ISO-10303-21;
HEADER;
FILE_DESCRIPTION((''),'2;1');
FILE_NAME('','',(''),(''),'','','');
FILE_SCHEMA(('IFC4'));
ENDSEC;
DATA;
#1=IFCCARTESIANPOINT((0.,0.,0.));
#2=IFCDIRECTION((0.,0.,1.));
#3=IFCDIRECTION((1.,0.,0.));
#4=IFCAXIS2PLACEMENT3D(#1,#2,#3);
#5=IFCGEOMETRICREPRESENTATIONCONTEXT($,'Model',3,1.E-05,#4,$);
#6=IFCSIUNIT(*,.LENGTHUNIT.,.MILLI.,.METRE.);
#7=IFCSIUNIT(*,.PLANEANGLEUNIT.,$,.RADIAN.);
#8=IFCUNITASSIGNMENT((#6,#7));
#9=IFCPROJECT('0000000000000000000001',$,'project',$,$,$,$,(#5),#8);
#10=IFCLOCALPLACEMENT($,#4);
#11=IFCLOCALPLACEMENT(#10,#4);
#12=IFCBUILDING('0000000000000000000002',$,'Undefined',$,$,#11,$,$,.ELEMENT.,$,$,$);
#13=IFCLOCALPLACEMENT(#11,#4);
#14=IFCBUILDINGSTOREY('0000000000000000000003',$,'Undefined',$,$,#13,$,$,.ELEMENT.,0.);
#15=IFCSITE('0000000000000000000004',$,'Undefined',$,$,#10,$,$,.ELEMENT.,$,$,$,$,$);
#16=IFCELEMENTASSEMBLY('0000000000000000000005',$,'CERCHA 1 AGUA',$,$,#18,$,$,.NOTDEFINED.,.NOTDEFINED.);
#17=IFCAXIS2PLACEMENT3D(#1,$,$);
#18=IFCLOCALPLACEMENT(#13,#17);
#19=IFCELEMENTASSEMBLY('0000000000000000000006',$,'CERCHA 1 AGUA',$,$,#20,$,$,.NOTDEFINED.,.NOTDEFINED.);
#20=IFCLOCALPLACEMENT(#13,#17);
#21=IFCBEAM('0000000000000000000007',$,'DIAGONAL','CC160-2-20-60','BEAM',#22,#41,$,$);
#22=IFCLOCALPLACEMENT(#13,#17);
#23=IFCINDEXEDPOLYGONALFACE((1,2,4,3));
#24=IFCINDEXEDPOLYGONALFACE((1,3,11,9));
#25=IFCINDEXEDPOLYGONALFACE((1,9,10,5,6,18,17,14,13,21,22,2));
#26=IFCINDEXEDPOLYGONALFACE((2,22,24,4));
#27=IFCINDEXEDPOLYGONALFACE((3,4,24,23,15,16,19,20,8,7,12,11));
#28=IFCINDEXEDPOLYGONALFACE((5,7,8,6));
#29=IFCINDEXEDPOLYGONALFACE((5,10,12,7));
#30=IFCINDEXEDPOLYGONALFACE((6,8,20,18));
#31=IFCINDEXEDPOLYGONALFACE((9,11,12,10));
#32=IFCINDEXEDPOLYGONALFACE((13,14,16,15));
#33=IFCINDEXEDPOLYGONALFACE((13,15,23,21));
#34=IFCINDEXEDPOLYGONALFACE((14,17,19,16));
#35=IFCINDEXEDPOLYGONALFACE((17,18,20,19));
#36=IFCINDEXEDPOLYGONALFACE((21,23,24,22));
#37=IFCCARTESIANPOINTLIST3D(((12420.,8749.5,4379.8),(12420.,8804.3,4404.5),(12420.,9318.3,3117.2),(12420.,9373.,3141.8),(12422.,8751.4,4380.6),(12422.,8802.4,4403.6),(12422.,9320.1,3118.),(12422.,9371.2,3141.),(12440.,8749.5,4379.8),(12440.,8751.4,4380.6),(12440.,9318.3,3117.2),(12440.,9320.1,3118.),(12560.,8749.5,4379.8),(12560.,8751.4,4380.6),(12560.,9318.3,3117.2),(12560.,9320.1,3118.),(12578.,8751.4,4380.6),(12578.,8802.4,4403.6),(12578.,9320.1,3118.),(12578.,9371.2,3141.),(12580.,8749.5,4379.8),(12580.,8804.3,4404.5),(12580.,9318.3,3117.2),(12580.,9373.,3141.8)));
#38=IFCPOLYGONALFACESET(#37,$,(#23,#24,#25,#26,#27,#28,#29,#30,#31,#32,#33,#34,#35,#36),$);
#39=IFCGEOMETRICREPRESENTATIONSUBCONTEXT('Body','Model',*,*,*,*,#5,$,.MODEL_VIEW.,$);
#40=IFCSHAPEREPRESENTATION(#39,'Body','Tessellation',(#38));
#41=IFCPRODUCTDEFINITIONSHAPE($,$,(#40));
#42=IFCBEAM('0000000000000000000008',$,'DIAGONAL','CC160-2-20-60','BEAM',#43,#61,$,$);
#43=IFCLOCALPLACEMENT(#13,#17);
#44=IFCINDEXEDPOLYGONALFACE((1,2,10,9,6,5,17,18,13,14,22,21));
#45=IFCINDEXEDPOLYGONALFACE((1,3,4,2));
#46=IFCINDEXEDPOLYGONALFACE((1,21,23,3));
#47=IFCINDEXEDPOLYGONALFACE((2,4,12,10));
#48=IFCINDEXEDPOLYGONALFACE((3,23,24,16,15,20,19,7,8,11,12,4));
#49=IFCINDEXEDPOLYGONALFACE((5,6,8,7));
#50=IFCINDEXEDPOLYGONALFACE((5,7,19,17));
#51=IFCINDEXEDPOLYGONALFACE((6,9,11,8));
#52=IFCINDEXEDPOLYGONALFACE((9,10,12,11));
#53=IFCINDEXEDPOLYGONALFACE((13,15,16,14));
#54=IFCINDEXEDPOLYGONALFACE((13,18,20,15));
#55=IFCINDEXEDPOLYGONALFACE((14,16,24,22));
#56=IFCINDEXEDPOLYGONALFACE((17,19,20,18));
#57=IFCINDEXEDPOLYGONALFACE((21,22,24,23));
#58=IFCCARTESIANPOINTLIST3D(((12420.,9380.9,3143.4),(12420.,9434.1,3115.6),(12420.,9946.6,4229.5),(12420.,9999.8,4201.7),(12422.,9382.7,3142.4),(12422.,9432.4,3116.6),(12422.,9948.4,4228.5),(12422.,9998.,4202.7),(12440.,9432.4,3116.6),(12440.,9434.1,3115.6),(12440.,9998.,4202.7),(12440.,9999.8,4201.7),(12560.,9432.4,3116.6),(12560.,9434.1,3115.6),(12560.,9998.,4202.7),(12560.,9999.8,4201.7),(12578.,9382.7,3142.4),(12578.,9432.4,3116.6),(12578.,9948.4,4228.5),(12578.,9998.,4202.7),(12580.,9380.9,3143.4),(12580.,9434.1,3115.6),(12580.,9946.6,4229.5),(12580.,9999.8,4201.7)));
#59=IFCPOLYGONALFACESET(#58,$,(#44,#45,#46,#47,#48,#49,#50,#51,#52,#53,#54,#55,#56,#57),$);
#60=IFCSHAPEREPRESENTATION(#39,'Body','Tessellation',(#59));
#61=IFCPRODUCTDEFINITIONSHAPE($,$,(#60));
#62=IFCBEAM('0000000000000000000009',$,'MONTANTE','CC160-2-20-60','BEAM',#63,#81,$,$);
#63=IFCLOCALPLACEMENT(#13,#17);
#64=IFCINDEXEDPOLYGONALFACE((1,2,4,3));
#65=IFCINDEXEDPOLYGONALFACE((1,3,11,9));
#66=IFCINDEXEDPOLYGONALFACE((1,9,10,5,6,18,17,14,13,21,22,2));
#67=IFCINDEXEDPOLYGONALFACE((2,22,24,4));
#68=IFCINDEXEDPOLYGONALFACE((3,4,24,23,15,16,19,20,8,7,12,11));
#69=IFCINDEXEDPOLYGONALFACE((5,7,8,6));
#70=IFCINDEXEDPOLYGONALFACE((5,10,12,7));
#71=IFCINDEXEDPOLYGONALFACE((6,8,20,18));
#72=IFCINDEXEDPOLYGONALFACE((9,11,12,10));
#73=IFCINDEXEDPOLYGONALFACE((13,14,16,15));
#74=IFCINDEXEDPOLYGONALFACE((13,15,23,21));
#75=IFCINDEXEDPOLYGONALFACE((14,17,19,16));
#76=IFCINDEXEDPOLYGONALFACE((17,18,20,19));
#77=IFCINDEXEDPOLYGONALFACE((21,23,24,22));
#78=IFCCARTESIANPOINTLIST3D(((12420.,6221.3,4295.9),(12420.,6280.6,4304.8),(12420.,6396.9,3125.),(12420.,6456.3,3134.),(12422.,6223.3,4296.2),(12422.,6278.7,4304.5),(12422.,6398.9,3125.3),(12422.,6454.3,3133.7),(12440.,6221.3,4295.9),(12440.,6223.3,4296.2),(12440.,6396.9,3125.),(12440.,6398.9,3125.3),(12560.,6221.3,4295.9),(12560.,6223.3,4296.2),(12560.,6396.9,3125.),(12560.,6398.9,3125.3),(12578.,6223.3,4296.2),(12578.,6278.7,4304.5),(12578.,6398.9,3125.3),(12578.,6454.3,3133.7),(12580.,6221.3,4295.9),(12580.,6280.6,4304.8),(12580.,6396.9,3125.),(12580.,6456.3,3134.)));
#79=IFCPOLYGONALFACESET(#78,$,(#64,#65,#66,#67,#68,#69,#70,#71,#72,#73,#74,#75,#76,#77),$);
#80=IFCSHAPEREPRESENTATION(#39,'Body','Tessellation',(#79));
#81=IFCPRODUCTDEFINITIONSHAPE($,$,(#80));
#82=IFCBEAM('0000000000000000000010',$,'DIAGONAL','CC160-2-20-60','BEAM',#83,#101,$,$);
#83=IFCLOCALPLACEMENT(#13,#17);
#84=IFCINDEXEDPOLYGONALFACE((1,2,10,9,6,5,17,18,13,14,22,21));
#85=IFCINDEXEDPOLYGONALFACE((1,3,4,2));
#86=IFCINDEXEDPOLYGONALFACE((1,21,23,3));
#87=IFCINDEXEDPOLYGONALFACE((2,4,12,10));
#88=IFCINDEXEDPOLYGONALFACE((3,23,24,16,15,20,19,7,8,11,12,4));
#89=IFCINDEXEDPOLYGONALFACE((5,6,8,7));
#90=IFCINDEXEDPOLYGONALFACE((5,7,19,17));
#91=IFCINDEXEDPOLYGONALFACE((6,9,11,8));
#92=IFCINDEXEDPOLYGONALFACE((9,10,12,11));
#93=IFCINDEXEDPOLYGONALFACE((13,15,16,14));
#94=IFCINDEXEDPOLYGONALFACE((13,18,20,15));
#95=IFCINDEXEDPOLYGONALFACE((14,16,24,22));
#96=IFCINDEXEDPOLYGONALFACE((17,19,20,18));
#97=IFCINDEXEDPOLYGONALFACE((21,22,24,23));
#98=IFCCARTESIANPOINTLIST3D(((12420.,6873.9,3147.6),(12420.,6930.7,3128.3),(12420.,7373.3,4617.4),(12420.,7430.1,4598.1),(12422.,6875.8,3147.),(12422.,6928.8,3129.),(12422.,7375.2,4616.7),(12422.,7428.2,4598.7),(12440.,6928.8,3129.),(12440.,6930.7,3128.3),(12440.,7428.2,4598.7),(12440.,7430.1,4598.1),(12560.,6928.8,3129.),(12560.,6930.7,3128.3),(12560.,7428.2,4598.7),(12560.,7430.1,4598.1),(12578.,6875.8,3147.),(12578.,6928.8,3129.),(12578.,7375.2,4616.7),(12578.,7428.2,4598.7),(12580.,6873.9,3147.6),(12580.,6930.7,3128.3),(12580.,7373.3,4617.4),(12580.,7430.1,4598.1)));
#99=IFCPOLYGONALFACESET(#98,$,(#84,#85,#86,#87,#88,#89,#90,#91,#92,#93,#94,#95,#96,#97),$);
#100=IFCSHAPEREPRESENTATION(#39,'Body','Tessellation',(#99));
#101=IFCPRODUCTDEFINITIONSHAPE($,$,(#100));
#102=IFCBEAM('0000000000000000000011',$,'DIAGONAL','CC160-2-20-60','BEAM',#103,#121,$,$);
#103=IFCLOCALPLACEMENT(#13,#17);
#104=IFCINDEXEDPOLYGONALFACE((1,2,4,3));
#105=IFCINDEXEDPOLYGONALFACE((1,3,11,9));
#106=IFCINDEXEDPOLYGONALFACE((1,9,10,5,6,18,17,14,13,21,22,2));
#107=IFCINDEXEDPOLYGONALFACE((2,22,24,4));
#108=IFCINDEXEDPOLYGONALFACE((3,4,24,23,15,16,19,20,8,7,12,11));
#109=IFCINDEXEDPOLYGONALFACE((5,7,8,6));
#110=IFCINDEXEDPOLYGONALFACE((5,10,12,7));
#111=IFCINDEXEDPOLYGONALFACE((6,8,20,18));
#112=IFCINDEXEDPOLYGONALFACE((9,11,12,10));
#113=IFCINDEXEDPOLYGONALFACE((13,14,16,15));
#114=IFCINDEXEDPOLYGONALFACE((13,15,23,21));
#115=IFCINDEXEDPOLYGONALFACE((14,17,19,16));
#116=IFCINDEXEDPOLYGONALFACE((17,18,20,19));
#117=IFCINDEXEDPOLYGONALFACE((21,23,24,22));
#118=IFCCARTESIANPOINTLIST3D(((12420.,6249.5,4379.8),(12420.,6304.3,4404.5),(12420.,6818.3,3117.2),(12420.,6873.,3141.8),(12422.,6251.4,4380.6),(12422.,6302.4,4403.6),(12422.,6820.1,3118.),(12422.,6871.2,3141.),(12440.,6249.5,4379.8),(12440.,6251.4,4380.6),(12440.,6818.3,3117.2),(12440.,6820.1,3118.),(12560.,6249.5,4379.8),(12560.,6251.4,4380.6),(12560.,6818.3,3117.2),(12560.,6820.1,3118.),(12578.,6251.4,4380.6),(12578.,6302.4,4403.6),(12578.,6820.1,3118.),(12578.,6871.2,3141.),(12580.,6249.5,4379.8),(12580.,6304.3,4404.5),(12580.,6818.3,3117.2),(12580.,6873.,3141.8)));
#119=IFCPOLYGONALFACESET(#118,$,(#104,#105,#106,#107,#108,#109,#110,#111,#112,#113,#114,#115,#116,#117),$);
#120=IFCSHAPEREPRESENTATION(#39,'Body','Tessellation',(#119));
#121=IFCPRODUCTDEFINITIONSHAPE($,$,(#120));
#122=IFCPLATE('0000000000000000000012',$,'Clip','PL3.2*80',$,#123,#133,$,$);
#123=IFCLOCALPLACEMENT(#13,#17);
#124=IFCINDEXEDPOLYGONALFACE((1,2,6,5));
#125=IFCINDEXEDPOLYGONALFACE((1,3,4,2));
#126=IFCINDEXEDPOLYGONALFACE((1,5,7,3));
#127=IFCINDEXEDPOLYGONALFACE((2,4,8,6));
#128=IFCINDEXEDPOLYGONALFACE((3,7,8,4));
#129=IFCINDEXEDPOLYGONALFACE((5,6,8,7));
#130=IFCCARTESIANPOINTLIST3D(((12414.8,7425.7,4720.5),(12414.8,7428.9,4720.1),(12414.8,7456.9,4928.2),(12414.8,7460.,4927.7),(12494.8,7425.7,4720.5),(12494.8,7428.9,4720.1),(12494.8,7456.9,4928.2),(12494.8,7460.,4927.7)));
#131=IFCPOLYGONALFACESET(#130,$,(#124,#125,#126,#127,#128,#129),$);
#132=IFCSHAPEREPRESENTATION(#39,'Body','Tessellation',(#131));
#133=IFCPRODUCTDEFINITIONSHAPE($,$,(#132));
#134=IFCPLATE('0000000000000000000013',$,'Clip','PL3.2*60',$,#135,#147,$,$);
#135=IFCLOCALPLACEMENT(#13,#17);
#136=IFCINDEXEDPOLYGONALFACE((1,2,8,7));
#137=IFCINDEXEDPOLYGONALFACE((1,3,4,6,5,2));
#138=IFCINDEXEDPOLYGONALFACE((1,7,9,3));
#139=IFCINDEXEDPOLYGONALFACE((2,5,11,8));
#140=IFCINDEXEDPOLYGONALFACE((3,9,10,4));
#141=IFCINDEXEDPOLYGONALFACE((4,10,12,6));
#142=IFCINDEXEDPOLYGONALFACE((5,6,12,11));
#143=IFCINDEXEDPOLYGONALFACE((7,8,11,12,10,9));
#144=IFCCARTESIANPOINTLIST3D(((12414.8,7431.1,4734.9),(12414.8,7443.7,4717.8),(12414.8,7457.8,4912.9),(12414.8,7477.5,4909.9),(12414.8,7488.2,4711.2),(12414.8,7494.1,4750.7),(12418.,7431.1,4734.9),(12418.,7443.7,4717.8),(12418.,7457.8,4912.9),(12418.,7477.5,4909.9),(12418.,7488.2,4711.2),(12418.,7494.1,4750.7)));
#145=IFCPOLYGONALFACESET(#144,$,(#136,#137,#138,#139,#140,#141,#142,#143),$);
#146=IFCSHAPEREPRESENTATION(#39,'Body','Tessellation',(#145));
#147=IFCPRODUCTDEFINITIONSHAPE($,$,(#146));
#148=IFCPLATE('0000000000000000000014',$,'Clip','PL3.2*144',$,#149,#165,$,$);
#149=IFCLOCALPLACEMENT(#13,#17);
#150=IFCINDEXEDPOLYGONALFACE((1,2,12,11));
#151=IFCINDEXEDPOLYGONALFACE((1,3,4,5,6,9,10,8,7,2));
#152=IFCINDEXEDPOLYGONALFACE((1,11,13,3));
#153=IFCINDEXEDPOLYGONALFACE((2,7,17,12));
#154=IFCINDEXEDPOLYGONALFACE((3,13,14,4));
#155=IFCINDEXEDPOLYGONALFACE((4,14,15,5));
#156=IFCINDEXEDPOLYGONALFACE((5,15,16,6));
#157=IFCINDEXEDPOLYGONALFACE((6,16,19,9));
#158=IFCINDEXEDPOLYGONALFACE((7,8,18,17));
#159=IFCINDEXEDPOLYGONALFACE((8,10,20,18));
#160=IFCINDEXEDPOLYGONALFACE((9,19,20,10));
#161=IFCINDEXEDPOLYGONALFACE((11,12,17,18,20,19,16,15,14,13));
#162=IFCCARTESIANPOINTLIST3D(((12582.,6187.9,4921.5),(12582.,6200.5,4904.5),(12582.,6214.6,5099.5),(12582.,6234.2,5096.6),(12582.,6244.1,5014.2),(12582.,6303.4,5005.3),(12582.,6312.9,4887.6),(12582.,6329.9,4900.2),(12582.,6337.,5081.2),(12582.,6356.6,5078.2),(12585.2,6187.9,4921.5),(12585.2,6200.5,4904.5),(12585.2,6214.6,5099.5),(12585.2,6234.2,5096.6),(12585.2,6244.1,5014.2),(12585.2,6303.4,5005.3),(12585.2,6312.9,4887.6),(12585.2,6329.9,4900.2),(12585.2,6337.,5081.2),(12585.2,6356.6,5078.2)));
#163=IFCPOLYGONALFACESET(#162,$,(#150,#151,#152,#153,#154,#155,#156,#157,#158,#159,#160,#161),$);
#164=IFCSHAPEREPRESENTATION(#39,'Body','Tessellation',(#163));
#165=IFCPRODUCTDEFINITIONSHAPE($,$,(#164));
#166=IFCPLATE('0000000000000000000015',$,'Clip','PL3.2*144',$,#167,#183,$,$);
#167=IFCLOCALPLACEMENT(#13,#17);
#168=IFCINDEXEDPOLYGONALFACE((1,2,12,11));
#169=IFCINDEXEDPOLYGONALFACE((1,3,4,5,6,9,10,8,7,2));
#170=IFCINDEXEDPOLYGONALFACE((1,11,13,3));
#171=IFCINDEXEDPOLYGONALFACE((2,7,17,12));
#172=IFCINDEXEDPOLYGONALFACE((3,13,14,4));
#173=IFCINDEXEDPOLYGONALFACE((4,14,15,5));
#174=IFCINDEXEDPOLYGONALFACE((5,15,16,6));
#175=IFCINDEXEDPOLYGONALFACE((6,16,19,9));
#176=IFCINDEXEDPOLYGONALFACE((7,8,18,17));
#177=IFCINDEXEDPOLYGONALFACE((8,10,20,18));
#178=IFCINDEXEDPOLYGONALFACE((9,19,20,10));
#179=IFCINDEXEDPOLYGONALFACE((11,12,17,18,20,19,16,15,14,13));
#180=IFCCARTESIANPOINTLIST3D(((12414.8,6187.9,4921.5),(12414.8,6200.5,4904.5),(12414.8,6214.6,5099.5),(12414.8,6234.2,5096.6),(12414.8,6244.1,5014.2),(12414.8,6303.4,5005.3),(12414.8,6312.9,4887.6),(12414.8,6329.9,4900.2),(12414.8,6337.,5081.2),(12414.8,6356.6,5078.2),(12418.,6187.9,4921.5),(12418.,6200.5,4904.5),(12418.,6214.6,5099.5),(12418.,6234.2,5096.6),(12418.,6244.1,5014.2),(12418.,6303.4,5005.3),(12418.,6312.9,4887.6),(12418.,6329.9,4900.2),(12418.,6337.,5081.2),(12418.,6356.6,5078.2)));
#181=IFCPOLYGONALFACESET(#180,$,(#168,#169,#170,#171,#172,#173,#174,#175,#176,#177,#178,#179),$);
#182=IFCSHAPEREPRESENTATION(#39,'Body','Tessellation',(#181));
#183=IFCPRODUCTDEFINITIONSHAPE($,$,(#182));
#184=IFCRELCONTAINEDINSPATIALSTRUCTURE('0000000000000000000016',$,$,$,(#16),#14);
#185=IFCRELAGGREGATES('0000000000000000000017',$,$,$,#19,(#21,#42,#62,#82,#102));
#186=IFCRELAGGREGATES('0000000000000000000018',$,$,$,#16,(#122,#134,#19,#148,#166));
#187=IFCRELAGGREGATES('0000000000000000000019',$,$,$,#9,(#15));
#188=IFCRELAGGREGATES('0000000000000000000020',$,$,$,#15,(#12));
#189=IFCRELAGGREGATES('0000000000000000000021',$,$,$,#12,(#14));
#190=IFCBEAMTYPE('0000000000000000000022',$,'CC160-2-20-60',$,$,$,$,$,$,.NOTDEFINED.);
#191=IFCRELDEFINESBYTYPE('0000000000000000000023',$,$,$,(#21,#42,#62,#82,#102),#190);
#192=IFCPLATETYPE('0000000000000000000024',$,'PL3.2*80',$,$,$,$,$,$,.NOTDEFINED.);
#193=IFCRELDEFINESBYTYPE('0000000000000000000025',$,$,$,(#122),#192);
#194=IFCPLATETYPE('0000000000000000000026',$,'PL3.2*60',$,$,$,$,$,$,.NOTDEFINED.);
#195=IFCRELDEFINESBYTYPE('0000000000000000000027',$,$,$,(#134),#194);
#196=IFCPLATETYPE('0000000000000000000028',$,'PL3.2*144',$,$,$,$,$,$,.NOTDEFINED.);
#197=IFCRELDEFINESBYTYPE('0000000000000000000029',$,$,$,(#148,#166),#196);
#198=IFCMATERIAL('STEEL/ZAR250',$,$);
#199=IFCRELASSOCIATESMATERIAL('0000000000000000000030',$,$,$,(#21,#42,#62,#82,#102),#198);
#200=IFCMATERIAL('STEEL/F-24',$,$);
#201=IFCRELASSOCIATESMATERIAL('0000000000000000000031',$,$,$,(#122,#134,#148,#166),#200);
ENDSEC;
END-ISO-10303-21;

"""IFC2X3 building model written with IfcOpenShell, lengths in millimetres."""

from ifc_helpers import new_model, si_unit, frame, origin_with_axes, origin_2d_with_axis, place, context, subcontext, project, spatial, polyline, c_section, outline, extrude, boolean, material, type_object, element, aggregate, save


model = new_model("IFC2X3")

# Units and contexts
model_context = context("Model", 3, precision=1e-05, world=origin_with_axes())
body_context = subcontext(model_context, "Body", "Model", "MODEL_VIEW")
ifc_project = project(units=[si_unit("LENGTHUNIT", "METRE", prefix="MILLI"), si_unit("PLANEANGLEUNIT", "RADIAN")], contexts=[model_context])

# Site, building, storey
site_placement = place(None, origin_with_axes())
site = spatial("IfcSite", under=ifc_project, at=site_placement, Name="Undefined", CompositionType="ELEMENT")
building_placement = place(site_placement, origin_with_axes())
building = spatial("IfcBuilding", under=site, at=building_placement, Name="Undefined", CompositionType="ELEMENT")
storey_placement = place(building_placement, origin_with_axes())
storey = spatial("IfcBuildingStorey", under=building, at=storey_placement, Name="Undefined", CompositionType="ELEMENT", Elevation=0.0)

# Element assemblies, beams, plates
assembly_1_placement = place(storey_placement, origin_with_axes())
assembly_1 = element("IfcElementAssembly", 1, at=assembly_1_placement, inside=storey, Name="CERCHA 1 AGUA", AssemblyPlace="NOTDEFINED", PredefinedType="NOTDEFINED")
assembly_2_placement = place(assembly_1_placement, origin_with_axes())
assembly_2 = element("IfcElementAssembly", 2, at=assembly_2_placement, Name="CERCHA 1 AGUA", AssemblyPlace="NOTDEFINED", PredefinedType="NOTDEFINED")
ifc_material_1 = material(Name="STEEL/ZAR250")
beam_type_1 = type_object("IfcBeamType", Name="CC160-2-20-60", PredefinedType="NOTDEFINED")
beam_1_placement = place(assembly_2_placement, frame((12500.0, 9345.7, 3129.5), z_axis=(-1.0, 0.0, 0.0), x_axis=(0.0, -0.410706, 0.911768)))
beam_1 = element("IfcBeam", 3, at=beam_1_placement, type_object=beam_type_1, material=ifc_material_1, Name="DIAGONAL", Description="CC160-2-20-60", ObjectType="BEAM", context=body_context, shape_type="SweptSolid", body=[
    extrude(c_section(Depth=160.0, Width=60.0, WallThickness=2.0, Girth=20.0, at=origin_2d_with_axis()), frame((1384.8, 0.0, 0.0), z_axis=(-1.0, 0.0, 0.0), x_axis=(0.0, -1.0, 0.0)), (0.0, 0.0, 1.0), 1384.8),
])
beam_2_placement = place(assembly_2_placement, frame((12500.0, 9973.2, 4215.6), z_axis=(-1.0, 0.0, 0.0), x_axis=(0.0, -0.461934, -0.886914)))
beam_2 = element("IfcBeam", 4, at=beam_2_placement, type_object=beam_type_1, material=ifc_material_1, Name="DIAGONAL", Description="CC160-2-20-60", ObjectType="BEAM", context=body_context, shape_type="SweptSolid", body=[
    extrude(c_section(Depth=160.0, Width=60.0, WallThickness=2.0, Girth=20.0, at=origin_2d_with_axis()), frame((1224.6, 0.0, 0.0), z_axis=(-1.0, 0.0, 0.0), x_axis=(0.0, -1.0, 0.0)), (0.0, 0.0, 1.0), 1224.6),
])
beam_3_placement = place(assembly_2_placement, frame((12500.0, 6251.0, 4300.4), z_axis=(1.0, 0.0, 0.0), x_axis=(0.0, 0.14834, -0.988936)))
beam_3 = element("IfcBeam", 5, at=beam_3_placement, type_object=beam_type_1, material=ifc_material_1, Name="MONTANTE", Description="CC160-2-20-60", ObjectType="BEAM", context=body_context, shape_type="SweptSolid", body=[
    extrude(c_section(Depth=160.0, Width=60.0, WallThickness=2.0, Girth=20.0, at=origin_2d_with_axis()), frame((1184.0, 0.0, 0.0), z_axis=(-1.0, 0.0, 0.0), x_axis=(0.0, -1.0, 0.0)), (0.0, 0.0, 1.0), 1184.0),
])
beam_4_placement = place(assembly_2_placement, frame((12500.0, 6902.3, 3138.0), z_axis=(1.0, 0.0, 0.0), x_axis=(0.0, 0.321737, 0.946829)))
beam_4 = element("IfcBeam", 6, at=beam_4_placement, type_object=beam_type_1, material=ifc_material_1, Name="DIAGONAL", Description="CC160-2-20-60", ObjectType="BEAM", context=body_context, shape_type="SweptSolid", body=[
    extrude(c_section(Depth=160.0, Width=60.0, WallThickness=2.0, Girth=20.0, at=origin_2d_with_axis()), frame((1552.3, 0.0, 0.0), z_axis=(-1.0, 0.0, 0.0), x_axis=(0.0, -1.0, 0.0)), (0.0, 0.0, 1.0), 1552.3),
])
beam_5_placement = place(assembly_2_placement, frame((12500.0, 6276.9, 4392.1), z_axis=(1.0, 0.0, 0.0), x_axis=(0.0, 0.410706, -0.911768)))
beam_5 = element("IfcBeam", 7, at=beam_5_placement, type_object=beam_type_1, material=ifc_material_1, Name="DIAGONAL", Description="CC160-2-20-60", ObjectType="BEAM", context=body_context, shape_type="SweptSolid", body=[
    extrude(c_section(Depth=160.0, Width=60.0, WallThickness=2.0, Girth=20.0, at=origin_2d_with_axis()), frame((1384.8, 0.0, 0.0), z_axis=(-1.0, 0.0, 0.0), x_axis=(0.0, -1.0, 0.0)), (0.0, 0.0, 1.0), 1384.8),
])
ifc_material_2 = material(Name="STEEL/F-24")
plate_type_1 = type_object("IfcPlateType", Name="PL3.2*80", PredefinedType="NOTDEFINED")
plate_1_placement = place(assembly_1_placement, frame((12494.8, 7427.3, 4720.3), z_axis=(0.0, 0.988921, -0.148445), x_axis=(-1.0, 0.0, 0.0)))
plate_1 = element("IfcPlate", 8, at=plate_1_placement, type_object=plate_type_1, material=ifc_material_2, Name="Clip", Description="PL3.2*80", context=body_context, shape_type="SweptSolid", body=[
    extrude(outline(polyline([(0.0, 0.0), (80.0, 0.0), (80.0, 210.0), (0.0, 210.0), (0.0, 0.0)])), frame((0.0, 0.0, -1.6), z_axis=(0.0, 0.0, 1.0), x_axis=(1.0, 0.0, 0.0)), (0.0, 0.0, 1.0), 3.2),
])
plate_type_2 = type_object("IfcPlateType", Name="PL3.2*60", PredefinedType="NOTDEFINED")
plate_2_placement = place(assembly_1_placement, frame((12416.4, 7517.1, 4904.0), z_axis=(-1.0, 0.0, 0.0), x_axis=(0.0, -0.148209, -0.988956)))
plate_2 = element("IfcPlate", 9, at=plate_2_placement, type_object=plate_type_2, material=ifc_material_2, Name="Clip", Description="PL3.2*60", context=body_context, shape_type="SweptSolid", body=[
    extrude(outline(polyline([(0.0, 40.0), (155.0, 0.0), (195.0, 0.0), (195.0, 45.0), (180.0, 60.0), (0.0, 60.0), (0.0, 40.0)])), frame((0.0, 0.0, -1.6), z_axis=(0.0, 0.0, 1.0), x_axis=(1.0, 0.0, 0.0)), (0.0, 0.0, 1.0), 3.2),
])
plate_type_3 = type_object("IfcPlateType", Name="PL3.2*144", PredefinedType="NOTDEFINED")
plate_3_placement = place(assembly_1_placement, frame((12583.6, 6356.6, 5078.2), z_axis=(-1.0, 0.0, 0.0), x_axis=(0.0, -0.148209, -0.988956)))
plate_3 = element("IfcPlate", 10, at=plate_3_placement, type_object=plate_type_3, material=ifc_material_2, Name="Clip", Description="PL3.2*144", context=body_context, shape_type="CSG", body=[
    boolean("DIFFERENCE", extrude(outline(polyline([(0.0, 0.0), (180.0, 0.0), (195.0, 15.0), (195.0, 128.6), (180.0, 143.6), (0.0, 143.6), (0.0, 0.0)])), frame((0.0, 0.0, -1.6), z_axis=(0.0, 0.0, 1.0), x_axis=(1.0, 0.0, 0.0)), (0.0, 0.0, 1.0), 3.2), extrude(outline(polyline([(0.0, 0.0), (103.9, 0.0), (82.0, 80.0), (22.0, 80.0), (0.0, 0.0)])), frame((0.0, 19.8, 4.5), z_axis=(0.0, 0.0, -1.0), x_axis=(-0.000027, 1.0, 0.0)), (0.0, 0.0, 1.0), 9.0)),
])
plate_4_placement = place(assembly_1_placement, frame((12416.4, 6356.6, 5078.2), z_axis=(-1.0, 0.0, 0.0), x_axis=(0.0, -0.148209, -0.988956)))
plate_4 = element("IfcPlate", 11, at=plate_4_placement, type_object=plate_type_3, material=ifc_material_2, Name="Clip", Description="PL3.2*144", context=body_context, shape_type="CSG", body=[
    boolean("DIFFERENCE", extrude(outline(polyline([(0.0, 0.0), (180.0, 0.0), (195.0, 15.0), (195.0, 128.6), (180.0, 143.6), (0.0, 143.6), (0.0, 0.0)])), frame((0.0, 0.0, -1.6), z_axis=(0.0, 0.0, 1.0), x_axis=(1.0, 0.0, 0.0)), (0.0, 0.0, 1.0), 3.2), extrude(outline(polyline([(0.0, 0.0), (103.9, 0.0), (82.0, 80.0), (22.0, 80.0), (0.0, 0.0)])), frame((0.0, 19.8, 4.5), z_axis=(0.0, 0.0, -1.0), x_axis=(-0.000027, 1.0, 0.0)), (0.0, 0.0, 1.0), 9.0)),
])

aggregate(assembly_2, [beam_1, beam_2, beam_3, beam_4, beam_5])
aggregate(assembly_1, [plate_1, plate_2, assembly_2, plate_3, plate_4])

save(model, "model.ifc")
